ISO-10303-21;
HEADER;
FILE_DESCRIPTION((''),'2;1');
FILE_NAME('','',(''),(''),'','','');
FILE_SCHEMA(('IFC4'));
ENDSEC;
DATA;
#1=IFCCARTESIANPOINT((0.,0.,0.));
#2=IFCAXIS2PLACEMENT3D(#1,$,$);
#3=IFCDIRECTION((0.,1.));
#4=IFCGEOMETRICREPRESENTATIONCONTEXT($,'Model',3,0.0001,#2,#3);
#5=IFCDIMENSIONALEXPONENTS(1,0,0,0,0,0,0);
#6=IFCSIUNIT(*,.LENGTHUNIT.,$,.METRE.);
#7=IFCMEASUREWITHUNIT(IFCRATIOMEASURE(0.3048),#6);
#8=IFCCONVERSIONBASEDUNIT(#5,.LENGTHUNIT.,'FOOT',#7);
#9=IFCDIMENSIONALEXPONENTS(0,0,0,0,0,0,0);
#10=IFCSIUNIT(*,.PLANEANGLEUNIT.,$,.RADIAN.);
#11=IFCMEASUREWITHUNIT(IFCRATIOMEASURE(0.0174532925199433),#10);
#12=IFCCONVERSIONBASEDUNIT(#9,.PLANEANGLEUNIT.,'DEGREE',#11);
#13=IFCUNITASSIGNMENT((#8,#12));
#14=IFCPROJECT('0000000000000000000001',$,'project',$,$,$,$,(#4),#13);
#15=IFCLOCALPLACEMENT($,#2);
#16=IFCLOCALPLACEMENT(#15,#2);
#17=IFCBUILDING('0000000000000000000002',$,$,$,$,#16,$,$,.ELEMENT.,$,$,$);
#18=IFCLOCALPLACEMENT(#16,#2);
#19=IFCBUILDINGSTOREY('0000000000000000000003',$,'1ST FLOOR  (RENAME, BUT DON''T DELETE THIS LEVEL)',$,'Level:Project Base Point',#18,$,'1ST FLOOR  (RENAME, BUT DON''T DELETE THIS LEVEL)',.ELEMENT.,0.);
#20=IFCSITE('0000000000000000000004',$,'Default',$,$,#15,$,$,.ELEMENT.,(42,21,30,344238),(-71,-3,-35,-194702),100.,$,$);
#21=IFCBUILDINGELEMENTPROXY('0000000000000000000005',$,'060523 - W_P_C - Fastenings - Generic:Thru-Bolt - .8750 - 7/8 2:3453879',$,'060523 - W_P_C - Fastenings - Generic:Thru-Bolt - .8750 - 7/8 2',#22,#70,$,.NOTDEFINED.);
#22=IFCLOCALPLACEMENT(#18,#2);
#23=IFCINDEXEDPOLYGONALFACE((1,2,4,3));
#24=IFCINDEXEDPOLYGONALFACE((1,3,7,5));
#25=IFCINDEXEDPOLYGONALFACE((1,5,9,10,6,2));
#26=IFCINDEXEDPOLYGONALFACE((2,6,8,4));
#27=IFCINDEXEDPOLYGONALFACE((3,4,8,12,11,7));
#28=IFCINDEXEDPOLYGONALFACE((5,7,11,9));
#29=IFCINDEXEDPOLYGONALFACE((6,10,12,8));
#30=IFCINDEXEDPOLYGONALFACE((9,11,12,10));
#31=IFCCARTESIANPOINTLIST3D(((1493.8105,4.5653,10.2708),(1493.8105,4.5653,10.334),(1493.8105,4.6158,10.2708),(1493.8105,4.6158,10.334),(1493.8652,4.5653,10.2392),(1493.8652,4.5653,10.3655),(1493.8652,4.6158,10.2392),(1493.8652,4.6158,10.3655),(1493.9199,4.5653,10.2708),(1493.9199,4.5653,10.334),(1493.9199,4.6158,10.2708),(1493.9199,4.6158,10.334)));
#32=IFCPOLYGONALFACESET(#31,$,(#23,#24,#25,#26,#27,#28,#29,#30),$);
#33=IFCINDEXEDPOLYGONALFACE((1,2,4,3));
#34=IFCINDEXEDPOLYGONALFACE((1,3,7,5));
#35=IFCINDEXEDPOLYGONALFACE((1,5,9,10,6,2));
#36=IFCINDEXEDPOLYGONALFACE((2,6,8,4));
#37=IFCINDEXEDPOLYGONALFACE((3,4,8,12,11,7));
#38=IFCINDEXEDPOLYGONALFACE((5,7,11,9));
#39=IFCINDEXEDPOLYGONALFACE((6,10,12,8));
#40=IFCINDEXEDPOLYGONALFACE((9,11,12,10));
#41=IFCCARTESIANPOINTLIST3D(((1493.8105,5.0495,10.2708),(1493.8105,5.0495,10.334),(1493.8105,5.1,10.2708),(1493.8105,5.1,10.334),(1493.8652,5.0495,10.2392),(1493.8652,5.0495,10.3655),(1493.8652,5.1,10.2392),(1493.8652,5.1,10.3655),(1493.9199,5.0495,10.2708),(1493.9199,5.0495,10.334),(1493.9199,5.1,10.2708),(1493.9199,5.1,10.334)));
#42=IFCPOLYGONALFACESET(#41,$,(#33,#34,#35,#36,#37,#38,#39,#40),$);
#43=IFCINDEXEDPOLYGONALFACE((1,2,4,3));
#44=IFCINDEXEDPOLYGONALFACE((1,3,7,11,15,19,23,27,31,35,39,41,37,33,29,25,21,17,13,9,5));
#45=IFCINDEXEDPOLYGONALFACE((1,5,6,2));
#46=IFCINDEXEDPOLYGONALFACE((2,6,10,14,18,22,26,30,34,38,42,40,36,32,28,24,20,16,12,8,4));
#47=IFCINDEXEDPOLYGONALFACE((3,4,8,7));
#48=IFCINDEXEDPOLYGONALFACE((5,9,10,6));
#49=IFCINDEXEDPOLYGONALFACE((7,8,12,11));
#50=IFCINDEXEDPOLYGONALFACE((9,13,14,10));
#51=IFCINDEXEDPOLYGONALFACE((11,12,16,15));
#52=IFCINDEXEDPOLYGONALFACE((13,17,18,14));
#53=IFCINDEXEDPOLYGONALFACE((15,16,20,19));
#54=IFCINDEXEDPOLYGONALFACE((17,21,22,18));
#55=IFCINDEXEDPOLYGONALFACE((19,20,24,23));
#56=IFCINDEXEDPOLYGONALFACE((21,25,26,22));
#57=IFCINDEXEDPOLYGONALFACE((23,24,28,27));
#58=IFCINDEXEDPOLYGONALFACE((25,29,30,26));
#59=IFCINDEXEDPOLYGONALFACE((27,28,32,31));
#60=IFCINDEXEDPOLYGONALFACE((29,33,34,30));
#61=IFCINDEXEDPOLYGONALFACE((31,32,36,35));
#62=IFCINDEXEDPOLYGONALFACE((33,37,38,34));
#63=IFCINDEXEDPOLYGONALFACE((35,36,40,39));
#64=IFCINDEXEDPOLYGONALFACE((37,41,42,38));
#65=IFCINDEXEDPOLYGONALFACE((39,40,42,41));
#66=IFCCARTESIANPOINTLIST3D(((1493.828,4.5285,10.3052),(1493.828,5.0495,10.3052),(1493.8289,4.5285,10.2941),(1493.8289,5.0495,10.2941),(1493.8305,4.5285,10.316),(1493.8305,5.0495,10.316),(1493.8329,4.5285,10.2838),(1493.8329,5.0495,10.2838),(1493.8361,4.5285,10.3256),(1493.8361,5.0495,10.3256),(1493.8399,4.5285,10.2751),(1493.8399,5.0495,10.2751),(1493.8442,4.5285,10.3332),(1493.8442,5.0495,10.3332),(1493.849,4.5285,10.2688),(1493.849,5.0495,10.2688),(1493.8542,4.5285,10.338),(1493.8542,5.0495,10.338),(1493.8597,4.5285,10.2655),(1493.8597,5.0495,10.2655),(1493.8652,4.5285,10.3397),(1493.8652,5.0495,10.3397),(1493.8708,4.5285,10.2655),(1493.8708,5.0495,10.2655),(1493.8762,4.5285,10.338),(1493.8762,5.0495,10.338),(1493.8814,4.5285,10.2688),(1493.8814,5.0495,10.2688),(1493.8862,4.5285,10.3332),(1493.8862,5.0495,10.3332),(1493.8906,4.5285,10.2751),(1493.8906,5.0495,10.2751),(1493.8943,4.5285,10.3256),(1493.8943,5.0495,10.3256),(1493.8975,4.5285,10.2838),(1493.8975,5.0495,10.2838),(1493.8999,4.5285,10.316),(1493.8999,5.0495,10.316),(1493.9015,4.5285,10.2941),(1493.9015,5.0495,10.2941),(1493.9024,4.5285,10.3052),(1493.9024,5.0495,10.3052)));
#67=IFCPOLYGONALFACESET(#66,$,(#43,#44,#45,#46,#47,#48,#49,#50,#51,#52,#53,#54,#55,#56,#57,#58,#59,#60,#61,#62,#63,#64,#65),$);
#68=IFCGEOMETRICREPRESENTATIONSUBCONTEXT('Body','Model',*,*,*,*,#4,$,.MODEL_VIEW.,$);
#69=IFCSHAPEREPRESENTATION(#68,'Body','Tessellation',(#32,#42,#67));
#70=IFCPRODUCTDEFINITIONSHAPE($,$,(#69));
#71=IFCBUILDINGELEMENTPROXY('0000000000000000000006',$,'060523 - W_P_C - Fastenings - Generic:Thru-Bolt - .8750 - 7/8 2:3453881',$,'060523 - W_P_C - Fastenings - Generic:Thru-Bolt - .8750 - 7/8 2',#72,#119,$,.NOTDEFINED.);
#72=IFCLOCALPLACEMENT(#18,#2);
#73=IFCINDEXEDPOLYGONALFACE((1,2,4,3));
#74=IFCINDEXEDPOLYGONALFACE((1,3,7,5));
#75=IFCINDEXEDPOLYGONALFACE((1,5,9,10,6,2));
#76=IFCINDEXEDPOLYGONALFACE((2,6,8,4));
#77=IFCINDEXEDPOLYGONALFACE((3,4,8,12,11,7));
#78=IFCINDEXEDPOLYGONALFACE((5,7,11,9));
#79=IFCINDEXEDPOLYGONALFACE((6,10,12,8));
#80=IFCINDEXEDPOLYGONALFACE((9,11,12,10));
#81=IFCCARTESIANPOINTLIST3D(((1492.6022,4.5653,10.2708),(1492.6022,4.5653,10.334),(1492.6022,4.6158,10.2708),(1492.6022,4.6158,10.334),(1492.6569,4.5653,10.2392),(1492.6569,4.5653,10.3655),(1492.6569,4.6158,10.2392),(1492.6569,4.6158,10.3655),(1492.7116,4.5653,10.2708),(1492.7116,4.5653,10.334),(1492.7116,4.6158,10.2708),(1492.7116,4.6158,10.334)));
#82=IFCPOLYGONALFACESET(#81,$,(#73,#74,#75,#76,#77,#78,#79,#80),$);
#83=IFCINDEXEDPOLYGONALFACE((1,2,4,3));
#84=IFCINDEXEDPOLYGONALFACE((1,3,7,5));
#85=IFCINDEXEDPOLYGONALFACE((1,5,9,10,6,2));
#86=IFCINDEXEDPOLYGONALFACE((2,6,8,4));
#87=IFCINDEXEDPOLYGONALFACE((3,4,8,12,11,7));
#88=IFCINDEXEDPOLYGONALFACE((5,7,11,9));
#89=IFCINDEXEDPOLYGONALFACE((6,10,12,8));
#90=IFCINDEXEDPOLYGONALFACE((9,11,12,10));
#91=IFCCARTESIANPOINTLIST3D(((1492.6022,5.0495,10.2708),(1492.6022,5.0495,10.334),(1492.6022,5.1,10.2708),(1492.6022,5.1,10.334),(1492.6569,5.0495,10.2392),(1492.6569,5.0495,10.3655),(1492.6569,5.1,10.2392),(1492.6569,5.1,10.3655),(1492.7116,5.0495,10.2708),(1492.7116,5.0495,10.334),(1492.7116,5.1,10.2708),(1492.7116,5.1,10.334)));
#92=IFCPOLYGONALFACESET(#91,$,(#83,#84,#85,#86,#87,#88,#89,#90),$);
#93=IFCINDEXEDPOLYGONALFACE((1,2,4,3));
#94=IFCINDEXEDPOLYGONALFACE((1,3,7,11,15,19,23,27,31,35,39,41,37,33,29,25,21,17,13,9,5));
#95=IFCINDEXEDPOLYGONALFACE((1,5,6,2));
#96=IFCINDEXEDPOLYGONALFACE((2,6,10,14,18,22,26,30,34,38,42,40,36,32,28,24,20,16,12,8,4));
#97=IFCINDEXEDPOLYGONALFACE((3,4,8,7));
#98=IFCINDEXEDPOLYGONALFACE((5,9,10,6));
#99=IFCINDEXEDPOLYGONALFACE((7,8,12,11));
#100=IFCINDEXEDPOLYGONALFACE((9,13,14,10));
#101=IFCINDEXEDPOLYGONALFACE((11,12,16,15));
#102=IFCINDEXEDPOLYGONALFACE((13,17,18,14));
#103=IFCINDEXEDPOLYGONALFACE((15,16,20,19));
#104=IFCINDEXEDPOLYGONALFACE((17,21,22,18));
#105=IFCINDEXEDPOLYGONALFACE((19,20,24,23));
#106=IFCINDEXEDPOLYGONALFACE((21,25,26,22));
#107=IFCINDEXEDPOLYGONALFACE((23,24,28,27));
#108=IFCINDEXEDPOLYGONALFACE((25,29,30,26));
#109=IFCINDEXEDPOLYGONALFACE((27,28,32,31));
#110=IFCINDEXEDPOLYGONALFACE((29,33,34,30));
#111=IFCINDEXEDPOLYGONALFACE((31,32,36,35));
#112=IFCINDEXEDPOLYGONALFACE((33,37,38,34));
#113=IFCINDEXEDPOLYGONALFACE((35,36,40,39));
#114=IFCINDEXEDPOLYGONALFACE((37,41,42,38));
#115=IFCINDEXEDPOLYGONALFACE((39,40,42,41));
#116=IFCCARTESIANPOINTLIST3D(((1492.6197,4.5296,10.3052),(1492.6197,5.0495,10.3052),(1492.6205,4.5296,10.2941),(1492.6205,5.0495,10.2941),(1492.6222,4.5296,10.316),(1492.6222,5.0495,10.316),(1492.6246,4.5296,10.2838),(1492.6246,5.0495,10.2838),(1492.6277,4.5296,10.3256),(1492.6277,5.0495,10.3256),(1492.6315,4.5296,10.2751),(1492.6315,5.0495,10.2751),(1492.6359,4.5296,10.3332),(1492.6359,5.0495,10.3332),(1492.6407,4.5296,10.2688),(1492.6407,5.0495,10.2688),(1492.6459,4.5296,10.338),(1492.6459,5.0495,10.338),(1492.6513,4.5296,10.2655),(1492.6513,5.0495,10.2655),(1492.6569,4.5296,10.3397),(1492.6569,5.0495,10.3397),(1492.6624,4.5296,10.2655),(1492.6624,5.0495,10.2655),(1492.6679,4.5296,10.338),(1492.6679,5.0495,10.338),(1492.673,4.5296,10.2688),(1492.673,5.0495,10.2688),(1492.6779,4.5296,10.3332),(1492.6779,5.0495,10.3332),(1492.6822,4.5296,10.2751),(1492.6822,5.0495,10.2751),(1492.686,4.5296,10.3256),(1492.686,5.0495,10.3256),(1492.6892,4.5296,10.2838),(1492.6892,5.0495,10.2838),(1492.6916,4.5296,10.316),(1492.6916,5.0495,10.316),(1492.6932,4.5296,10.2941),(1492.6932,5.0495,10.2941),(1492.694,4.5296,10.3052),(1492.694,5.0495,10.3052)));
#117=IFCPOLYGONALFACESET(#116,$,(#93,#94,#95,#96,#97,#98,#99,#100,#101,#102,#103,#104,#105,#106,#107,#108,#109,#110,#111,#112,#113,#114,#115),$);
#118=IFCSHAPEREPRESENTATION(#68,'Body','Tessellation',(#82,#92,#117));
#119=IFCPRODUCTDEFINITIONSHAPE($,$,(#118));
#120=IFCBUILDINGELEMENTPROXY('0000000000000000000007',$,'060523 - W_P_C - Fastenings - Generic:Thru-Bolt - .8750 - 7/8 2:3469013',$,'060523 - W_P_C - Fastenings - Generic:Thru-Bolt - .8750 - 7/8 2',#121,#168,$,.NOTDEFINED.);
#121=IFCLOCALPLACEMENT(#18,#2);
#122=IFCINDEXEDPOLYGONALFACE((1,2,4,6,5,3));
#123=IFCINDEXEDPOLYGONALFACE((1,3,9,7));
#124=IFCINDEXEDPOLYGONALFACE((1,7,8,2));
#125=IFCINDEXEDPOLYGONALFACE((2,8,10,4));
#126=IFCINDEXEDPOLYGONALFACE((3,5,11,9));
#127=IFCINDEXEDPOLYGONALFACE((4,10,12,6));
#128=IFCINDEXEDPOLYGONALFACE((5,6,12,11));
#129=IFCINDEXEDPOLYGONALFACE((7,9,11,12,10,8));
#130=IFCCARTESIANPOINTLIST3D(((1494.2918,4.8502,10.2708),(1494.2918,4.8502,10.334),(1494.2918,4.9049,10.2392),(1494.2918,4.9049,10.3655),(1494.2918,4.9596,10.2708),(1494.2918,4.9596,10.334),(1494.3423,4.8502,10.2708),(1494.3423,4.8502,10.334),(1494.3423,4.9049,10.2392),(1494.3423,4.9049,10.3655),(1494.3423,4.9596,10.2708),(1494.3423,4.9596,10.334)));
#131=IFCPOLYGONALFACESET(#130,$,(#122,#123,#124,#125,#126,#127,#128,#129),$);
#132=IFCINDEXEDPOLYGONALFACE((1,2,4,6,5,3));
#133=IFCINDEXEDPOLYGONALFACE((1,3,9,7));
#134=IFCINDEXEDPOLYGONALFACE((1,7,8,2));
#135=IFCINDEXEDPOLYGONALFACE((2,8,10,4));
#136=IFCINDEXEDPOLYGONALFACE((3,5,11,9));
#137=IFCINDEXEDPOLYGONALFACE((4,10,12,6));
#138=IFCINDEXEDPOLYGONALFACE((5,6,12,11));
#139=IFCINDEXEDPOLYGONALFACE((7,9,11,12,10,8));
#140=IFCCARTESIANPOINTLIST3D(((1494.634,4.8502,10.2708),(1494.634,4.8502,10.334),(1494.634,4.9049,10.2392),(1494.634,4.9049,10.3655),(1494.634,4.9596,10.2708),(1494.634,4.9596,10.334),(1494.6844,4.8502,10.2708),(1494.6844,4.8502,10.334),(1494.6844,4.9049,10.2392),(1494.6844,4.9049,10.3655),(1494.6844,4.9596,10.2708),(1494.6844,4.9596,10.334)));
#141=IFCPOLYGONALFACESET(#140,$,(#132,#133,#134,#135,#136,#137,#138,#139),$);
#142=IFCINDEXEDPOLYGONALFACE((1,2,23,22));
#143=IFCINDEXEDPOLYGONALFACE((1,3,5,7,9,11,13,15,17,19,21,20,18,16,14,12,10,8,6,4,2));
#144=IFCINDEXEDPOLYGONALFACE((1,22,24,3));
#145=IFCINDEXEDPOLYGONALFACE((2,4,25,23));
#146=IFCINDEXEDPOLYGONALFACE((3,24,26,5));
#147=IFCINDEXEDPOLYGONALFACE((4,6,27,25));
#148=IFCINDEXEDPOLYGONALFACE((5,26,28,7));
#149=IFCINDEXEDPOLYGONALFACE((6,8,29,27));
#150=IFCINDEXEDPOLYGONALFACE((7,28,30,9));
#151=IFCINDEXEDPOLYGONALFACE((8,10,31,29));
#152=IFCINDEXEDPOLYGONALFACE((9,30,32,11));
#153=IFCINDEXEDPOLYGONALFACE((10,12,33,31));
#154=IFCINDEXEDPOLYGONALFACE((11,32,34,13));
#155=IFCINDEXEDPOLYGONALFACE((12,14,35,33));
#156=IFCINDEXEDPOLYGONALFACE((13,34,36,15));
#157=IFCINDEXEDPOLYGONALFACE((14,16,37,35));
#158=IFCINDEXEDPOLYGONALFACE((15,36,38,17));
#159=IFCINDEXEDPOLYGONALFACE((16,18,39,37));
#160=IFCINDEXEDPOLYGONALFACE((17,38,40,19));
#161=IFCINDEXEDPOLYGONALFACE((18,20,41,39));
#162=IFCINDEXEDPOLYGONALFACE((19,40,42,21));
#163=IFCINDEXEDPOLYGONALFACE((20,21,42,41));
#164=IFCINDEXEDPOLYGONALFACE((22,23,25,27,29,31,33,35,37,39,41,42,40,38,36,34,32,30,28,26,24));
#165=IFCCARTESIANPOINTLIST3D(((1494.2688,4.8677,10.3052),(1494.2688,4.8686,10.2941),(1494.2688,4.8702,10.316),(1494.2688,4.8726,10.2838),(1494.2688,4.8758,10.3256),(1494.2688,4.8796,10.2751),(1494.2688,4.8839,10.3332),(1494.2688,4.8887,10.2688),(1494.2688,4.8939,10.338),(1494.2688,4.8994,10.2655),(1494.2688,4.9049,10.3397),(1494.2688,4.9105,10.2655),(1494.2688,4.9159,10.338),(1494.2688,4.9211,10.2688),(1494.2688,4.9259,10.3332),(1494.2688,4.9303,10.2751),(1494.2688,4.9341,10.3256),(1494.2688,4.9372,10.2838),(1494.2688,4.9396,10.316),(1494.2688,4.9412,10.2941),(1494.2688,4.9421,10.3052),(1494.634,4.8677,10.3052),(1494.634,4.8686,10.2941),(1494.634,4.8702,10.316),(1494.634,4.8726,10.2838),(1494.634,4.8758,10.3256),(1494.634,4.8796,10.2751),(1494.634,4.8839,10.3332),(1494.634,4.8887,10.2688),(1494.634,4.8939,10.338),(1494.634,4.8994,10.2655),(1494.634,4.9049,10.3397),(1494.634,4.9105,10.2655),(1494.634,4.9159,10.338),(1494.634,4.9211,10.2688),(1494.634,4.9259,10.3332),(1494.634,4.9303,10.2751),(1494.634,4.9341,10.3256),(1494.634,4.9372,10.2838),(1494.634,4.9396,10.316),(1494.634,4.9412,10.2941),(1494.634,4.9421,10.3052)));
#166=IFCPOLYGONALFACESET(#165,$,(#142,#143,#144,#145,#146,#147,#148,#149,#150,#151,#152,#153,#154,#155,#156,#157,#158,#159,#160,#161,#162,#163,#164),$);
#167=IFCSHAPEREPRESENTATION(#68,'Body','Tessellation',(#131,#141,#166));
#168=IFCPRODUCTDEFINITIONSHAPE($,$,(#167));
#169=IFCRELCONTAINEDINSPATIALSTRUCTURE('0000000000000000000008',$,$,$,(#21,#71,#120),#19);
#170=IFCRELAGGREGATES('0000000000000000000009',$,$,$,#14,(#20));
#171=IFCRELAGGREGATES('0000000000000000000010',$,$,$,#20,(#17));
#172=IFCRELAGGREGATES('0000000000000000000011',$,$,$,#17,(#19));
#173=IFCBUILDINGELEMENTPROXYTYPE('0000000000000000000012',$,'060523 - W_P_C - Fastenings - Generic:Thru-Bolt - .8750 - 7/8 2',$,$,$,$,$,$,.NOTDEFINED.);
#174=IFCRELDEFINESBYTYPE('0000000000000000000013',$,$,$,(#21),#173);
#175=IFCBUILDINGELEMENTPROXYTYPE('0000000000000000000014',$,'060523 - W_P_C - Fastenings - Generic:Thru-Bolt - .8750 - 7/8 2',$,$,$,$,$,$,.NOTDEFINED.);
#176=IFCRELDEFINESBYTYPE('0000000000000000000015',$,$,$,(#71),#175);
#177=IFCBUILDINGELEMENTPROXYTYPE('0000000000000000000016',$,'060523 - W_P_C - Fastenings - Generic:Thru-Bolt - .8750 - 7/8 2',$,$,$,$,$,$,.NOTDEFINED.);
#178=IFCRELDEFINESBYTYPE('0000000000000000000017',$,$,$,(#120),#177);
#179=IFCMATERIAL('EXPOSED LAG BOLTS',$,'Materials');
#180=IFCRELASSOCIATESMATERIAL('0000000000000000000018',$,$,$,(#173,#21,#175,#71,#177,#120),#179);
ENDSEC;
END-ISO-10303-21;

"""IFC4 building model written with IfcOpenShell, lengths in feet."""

from ifc_helpers import new_model, entity, si_unit, converted_unit, direction, frame, frame_2d, origin, place, context, subcontext, project, spatial, polyline, circle, outline, extrude, source, transform, mapped, material, type_object, type_shapes, element, save


model = new_model("IFC4")

# Units and contexts
model_context = context("Model", 3, precision=0.0001, world=origin(), true_north=direction((0.0, 1.0)))
body_context = subcontext(model_context, "Body", "Model", "MODEL_VIEW")
ifc_project = project(units=[converted_unit("LENGTHUNIT", "FOOT", entity("IfcRatioMeasure", 0.3048), si_unit("LENGTHUNIT", "METRE"), dimensions=[1, 0, 0, 0, 0, 0, 0]), converted_unit("PLANEANGLEUNIT", "DEGREE", entity("IfcRatioMeasure", 0.0174532925199433), si_unit("PLANEANGLEUNIT", "RADIAN"), dimensions=[0, 0, 0, 0, 0, 0, 0])], contexts=[model_context])

# Site, building, storey
site_placement = place(None, origin())
site = spatial("IfcSite", under=ifc_project, at=site_placement, Name="Default", CompositionType="ELEMENT", RefLatitude=(42, 21, 30, 344238), RefLongitude=(-71, -3, -35, -194702), RefElevation=100.0)
building_placement = place(site_placement, origin())
building = spatial("IfcBuilding", under=site, at=building_placement, CompositionType="ELEMENT")
storey_placement = place(building_placement, origin())
storey = spatial("IfcBuildingStorey", under=building, at=storey_placement, Name="1ST FLOOR  (RENAME, BUT DON'T DELETE THIS LEVEL)", ObjectType="Level:Project Base Point", LongName="1ST FLOOR  (RENAME, BUT DON'T DELETE THIS LEVEL)", CompositionType="ELEMENT", Elevation=0.0)

# Building element proxies
ifc_material_1 = material(Name="EXPOSED LAG BOLTS", Category="Materials")
building_element_proxy_type_1 = type_object("IfcBuildingElementProxyType", Name="060523 - W_P_C - Fastenings - Generic:Thru-Bolt - .8750 - 7/8 2", PredefinedType="NOTDEFINED", material=ifc_material_1)
shared_shape_1 = source(origin(), body_context, "Body", "SweptSolid", [
    extrude(outline(polyline([(-0.0316, -0.0547), (0.0316, -0.0547), (0.0631, 0.0), (0.0316, 0.0547), (-0.0316, 0.0547), (-0.0631, 0.0), (-0.0316, -0.0547)])), frame((0.0, 0.0, -0.4842), z_axis=(0.0, 0.0, 1.0), x_axis=(0.866025, -0.5, 0.0)), (0.0, 0.0, 1.0), 0.0505),
    extrude(outline(polyline([(-0.0316, -0.0547), (0.0316, -0.0547), (0.0631, 0.0), (0.0316, 0.0547), (-0.0316, 0.0547), (-0.0631, 0.0), (-0.0316, -0.0547)])), frame((0.0, 0.0, 0.0), z_axis=(0.0, 0.0, 1.0), x_axis=(0.0, -1.0, 0.0)), (0.0, 0.0, 1.0), 0.0505),
    extrude(circle(Radius=0.0373, at=frame_2d((0.0, 0.0), x_axis=(1.0, 0.0))), frame((0.0, 0.0, -0.521), z_axis=(0.0, 0.0, 1.0), x_axis=(0.0, 1.0, 0.0)), (0.0, 0.0, 1.0), 0.521),
])
type_shapes(building_element_proxy_type_1, [shared_shape_1])
proxy_1_placement = place(storey_placement, frame((1493.8652, 5.0495, 10.3024), z_axis=(0.0, 1.0, 0.0), x_axis=(-1.0, 0.0, 0.0)))
element("IfcBuildingElementProxy", 1, at=proxy_1_placement, inside=storey, type_object=building_element_proxy_type_1, material=ifc_material_1, Name="060523 - W_P_C - Fastenings - Generic:Thru-Bolt - .8750 - 7/8 2:3453879", ObjectType="060523 - W_P_C - Fastenings - Generic:Thru-Bolt - .8750 - 7/8 2", PredefinedType="NOTDEFINED", context=body_context, shape_type="MappedRepresentation", body=[
    mapped(shared_shape_1, transform((0.0, 0.0, 0.0), scale=1.0)),
])
building_element_proxy_type_2 = type_object("IfcBuildingElementProxyType", Name="060523 - W_P_C - Fastenings - Generic:Thru-Bolt - .8750 - 7/8 2", PredefinedType="NOTDEFINED", material=ifc_material_1)
shared_shape_2 = source(origin(), body_context, "Body", "SweptSolid", [
    extrude(outline(polyline([(-0.0316, -0.0547), (0.0316, -0.0547), (0.0631, 0.0), (0.0316, 0.0547), (-0.0316, 0.0547), (-0.0631, 0.0), (-0.0316, -0.0547)])), frame((0.0, 0.0, -0.4842), z_axis=(0.0, 0.0, 1.0), x_axis=(0.866025, -0.5, 0.0)), (0.0, 0.0, 1.0), 0.0505),
    extrude(outline(polyline([(-0.0316, -0.0547), (0.0316, -0.0547), (0.0631, 0.0), (0.0316, 0.0547), (-0.0316, 0.0547), (-0.0631, 0.0), (-0.0316, -0.0547)])), frame((0.0, 0.0, 0.0), z_axis=(0.0, 0.0, 1.0), x_axis=(0.0, -1.0, 0.0)), (0.0, 0.0, 1.0), 0.0505),
    extrude(circle(Radius=0.0373, at=frame_2d((0.0, 0.0), x_axis=(1.0, 0.0))), frame((0.0, 0.0, -0.5199), z_axis=(0.0, 0.0, 1.0), x_axis=(0.0, 1.0, 0.0)), (0.0, 0.0, 1.0), 0.5199),
])
type_shapes(building_element_proxy_type_2, [shared_shape_2])
proxy_2_placement = place(storey_placement, frame((1492.6569, 5.0495, 10.3024), z_axis=(0.0, 1.0, 0.0), x_axis=(-1.0, 0.0, 0.0)))
element("IfcBuildingElementProxy", 2, at=proxy_2_placement, inside=storey, type_object=building_element_proxy_type_2, material=ifc_material_1, Name="060523 - W_P_C - Fastenings - Generic:Thru-Bolt - .8750 - 7/8 2:3453881", ObjectType="060523 - W_P_C - Fastenings - Generic:Thru-Bolt - .8750 - 7/8 2", PredefinedType="NOTDEFINED", context=body_context, shape_type="MappedRepresentation", body=[
    mapped(shared_shape_2, transform((0.0, 0.0, 0.0), scale=1.0)),
])
building_element_proxy_type_3 = type_object("IfcBuildingElementProxyType", Name="060523 - W_P_C - Fastenings - Generic:Thru-Bolt - .8750 - 7/8 2", PredefinedType="NOTDEFINED", material=ifc_material_1)
shared_shape_3 = source(origin(), body_context, "Body", "SweptSolid", [
    extrude(outline(polyline([(-0.0316, -0.0547), (0.0316, -0.0547), (0.0631, 0.0), (0.0316, 0.0547), (-0.0316, 0.0547), (-0.0631, 0.0), (-0.0316, -0.0547)])), frame((0.0, 0.0, -0.3421), z_axis=(0.0, 0.0, 1.0), x_axis=(0.866025, -0.5, 0.0)), (0.0, 0.0, 1.0), 0.0505),
    extrude(outline(polyline([(-0.0316, -0.0547), (0.0316, -0.0547), (0.0631, 0.0), (0.0316, 0.0547), (-0.0316, 0.0547), (-0.0631, 0.0), (-0.0316, -0.0547)])), frame((0.0, 0.0, 0.0), z_axis=(0.0, 0.0, 1.0), x_axis=(0.0, -1.0, 0.0)), (0.0, 0.0, 1.0), 0.0505),
    extrude(circle(Radius=0.0373, at=frame_2d((0.0, 0.0), x_axis=(1.0, 0.0))), frame((0.0, 0.0, -0.3652), z_axis=(0.0, 0.0, 1.0), x_axis=(0.0, 1.0, 0.0)), (0.0, 0.0, 1.0), 0.3652),
])
type_shapes(building_element_proxy_type_3, [shared_shape_3])
for number, where, z_axis, x_axis, name in (
    (3, (1494.634, 4.9049, 10.3024), (1.0, 0.0, 0.0), (0.0, 1.0, 0.0), "060523 - W_P_C - Fastenings - Generic:Thru-Bolt - .8750 - 7/8 2:3469013"),
):
    element("IfcBuildingElementProxy", number, at=place(storey_placement, frame(where, z_axis=z_axis, x_axis=x_axis)), inside=storey, type_object=building_element_proxy_type_3, material=ifc_material_1, Name=name, ObjectType="060523 - W_P_C - Fastenings - Generic:Thru-Bolt - .8750 - 7/8 2", PredefinedType="NOTDEFINED", context=body_context, shape_type="MappedRepresentation", body=[
        mapped(shared_shape_3, transform((0.0, 0.0, 0.0), scale=1.0)),
    ])

save(model, "model.ifc")
